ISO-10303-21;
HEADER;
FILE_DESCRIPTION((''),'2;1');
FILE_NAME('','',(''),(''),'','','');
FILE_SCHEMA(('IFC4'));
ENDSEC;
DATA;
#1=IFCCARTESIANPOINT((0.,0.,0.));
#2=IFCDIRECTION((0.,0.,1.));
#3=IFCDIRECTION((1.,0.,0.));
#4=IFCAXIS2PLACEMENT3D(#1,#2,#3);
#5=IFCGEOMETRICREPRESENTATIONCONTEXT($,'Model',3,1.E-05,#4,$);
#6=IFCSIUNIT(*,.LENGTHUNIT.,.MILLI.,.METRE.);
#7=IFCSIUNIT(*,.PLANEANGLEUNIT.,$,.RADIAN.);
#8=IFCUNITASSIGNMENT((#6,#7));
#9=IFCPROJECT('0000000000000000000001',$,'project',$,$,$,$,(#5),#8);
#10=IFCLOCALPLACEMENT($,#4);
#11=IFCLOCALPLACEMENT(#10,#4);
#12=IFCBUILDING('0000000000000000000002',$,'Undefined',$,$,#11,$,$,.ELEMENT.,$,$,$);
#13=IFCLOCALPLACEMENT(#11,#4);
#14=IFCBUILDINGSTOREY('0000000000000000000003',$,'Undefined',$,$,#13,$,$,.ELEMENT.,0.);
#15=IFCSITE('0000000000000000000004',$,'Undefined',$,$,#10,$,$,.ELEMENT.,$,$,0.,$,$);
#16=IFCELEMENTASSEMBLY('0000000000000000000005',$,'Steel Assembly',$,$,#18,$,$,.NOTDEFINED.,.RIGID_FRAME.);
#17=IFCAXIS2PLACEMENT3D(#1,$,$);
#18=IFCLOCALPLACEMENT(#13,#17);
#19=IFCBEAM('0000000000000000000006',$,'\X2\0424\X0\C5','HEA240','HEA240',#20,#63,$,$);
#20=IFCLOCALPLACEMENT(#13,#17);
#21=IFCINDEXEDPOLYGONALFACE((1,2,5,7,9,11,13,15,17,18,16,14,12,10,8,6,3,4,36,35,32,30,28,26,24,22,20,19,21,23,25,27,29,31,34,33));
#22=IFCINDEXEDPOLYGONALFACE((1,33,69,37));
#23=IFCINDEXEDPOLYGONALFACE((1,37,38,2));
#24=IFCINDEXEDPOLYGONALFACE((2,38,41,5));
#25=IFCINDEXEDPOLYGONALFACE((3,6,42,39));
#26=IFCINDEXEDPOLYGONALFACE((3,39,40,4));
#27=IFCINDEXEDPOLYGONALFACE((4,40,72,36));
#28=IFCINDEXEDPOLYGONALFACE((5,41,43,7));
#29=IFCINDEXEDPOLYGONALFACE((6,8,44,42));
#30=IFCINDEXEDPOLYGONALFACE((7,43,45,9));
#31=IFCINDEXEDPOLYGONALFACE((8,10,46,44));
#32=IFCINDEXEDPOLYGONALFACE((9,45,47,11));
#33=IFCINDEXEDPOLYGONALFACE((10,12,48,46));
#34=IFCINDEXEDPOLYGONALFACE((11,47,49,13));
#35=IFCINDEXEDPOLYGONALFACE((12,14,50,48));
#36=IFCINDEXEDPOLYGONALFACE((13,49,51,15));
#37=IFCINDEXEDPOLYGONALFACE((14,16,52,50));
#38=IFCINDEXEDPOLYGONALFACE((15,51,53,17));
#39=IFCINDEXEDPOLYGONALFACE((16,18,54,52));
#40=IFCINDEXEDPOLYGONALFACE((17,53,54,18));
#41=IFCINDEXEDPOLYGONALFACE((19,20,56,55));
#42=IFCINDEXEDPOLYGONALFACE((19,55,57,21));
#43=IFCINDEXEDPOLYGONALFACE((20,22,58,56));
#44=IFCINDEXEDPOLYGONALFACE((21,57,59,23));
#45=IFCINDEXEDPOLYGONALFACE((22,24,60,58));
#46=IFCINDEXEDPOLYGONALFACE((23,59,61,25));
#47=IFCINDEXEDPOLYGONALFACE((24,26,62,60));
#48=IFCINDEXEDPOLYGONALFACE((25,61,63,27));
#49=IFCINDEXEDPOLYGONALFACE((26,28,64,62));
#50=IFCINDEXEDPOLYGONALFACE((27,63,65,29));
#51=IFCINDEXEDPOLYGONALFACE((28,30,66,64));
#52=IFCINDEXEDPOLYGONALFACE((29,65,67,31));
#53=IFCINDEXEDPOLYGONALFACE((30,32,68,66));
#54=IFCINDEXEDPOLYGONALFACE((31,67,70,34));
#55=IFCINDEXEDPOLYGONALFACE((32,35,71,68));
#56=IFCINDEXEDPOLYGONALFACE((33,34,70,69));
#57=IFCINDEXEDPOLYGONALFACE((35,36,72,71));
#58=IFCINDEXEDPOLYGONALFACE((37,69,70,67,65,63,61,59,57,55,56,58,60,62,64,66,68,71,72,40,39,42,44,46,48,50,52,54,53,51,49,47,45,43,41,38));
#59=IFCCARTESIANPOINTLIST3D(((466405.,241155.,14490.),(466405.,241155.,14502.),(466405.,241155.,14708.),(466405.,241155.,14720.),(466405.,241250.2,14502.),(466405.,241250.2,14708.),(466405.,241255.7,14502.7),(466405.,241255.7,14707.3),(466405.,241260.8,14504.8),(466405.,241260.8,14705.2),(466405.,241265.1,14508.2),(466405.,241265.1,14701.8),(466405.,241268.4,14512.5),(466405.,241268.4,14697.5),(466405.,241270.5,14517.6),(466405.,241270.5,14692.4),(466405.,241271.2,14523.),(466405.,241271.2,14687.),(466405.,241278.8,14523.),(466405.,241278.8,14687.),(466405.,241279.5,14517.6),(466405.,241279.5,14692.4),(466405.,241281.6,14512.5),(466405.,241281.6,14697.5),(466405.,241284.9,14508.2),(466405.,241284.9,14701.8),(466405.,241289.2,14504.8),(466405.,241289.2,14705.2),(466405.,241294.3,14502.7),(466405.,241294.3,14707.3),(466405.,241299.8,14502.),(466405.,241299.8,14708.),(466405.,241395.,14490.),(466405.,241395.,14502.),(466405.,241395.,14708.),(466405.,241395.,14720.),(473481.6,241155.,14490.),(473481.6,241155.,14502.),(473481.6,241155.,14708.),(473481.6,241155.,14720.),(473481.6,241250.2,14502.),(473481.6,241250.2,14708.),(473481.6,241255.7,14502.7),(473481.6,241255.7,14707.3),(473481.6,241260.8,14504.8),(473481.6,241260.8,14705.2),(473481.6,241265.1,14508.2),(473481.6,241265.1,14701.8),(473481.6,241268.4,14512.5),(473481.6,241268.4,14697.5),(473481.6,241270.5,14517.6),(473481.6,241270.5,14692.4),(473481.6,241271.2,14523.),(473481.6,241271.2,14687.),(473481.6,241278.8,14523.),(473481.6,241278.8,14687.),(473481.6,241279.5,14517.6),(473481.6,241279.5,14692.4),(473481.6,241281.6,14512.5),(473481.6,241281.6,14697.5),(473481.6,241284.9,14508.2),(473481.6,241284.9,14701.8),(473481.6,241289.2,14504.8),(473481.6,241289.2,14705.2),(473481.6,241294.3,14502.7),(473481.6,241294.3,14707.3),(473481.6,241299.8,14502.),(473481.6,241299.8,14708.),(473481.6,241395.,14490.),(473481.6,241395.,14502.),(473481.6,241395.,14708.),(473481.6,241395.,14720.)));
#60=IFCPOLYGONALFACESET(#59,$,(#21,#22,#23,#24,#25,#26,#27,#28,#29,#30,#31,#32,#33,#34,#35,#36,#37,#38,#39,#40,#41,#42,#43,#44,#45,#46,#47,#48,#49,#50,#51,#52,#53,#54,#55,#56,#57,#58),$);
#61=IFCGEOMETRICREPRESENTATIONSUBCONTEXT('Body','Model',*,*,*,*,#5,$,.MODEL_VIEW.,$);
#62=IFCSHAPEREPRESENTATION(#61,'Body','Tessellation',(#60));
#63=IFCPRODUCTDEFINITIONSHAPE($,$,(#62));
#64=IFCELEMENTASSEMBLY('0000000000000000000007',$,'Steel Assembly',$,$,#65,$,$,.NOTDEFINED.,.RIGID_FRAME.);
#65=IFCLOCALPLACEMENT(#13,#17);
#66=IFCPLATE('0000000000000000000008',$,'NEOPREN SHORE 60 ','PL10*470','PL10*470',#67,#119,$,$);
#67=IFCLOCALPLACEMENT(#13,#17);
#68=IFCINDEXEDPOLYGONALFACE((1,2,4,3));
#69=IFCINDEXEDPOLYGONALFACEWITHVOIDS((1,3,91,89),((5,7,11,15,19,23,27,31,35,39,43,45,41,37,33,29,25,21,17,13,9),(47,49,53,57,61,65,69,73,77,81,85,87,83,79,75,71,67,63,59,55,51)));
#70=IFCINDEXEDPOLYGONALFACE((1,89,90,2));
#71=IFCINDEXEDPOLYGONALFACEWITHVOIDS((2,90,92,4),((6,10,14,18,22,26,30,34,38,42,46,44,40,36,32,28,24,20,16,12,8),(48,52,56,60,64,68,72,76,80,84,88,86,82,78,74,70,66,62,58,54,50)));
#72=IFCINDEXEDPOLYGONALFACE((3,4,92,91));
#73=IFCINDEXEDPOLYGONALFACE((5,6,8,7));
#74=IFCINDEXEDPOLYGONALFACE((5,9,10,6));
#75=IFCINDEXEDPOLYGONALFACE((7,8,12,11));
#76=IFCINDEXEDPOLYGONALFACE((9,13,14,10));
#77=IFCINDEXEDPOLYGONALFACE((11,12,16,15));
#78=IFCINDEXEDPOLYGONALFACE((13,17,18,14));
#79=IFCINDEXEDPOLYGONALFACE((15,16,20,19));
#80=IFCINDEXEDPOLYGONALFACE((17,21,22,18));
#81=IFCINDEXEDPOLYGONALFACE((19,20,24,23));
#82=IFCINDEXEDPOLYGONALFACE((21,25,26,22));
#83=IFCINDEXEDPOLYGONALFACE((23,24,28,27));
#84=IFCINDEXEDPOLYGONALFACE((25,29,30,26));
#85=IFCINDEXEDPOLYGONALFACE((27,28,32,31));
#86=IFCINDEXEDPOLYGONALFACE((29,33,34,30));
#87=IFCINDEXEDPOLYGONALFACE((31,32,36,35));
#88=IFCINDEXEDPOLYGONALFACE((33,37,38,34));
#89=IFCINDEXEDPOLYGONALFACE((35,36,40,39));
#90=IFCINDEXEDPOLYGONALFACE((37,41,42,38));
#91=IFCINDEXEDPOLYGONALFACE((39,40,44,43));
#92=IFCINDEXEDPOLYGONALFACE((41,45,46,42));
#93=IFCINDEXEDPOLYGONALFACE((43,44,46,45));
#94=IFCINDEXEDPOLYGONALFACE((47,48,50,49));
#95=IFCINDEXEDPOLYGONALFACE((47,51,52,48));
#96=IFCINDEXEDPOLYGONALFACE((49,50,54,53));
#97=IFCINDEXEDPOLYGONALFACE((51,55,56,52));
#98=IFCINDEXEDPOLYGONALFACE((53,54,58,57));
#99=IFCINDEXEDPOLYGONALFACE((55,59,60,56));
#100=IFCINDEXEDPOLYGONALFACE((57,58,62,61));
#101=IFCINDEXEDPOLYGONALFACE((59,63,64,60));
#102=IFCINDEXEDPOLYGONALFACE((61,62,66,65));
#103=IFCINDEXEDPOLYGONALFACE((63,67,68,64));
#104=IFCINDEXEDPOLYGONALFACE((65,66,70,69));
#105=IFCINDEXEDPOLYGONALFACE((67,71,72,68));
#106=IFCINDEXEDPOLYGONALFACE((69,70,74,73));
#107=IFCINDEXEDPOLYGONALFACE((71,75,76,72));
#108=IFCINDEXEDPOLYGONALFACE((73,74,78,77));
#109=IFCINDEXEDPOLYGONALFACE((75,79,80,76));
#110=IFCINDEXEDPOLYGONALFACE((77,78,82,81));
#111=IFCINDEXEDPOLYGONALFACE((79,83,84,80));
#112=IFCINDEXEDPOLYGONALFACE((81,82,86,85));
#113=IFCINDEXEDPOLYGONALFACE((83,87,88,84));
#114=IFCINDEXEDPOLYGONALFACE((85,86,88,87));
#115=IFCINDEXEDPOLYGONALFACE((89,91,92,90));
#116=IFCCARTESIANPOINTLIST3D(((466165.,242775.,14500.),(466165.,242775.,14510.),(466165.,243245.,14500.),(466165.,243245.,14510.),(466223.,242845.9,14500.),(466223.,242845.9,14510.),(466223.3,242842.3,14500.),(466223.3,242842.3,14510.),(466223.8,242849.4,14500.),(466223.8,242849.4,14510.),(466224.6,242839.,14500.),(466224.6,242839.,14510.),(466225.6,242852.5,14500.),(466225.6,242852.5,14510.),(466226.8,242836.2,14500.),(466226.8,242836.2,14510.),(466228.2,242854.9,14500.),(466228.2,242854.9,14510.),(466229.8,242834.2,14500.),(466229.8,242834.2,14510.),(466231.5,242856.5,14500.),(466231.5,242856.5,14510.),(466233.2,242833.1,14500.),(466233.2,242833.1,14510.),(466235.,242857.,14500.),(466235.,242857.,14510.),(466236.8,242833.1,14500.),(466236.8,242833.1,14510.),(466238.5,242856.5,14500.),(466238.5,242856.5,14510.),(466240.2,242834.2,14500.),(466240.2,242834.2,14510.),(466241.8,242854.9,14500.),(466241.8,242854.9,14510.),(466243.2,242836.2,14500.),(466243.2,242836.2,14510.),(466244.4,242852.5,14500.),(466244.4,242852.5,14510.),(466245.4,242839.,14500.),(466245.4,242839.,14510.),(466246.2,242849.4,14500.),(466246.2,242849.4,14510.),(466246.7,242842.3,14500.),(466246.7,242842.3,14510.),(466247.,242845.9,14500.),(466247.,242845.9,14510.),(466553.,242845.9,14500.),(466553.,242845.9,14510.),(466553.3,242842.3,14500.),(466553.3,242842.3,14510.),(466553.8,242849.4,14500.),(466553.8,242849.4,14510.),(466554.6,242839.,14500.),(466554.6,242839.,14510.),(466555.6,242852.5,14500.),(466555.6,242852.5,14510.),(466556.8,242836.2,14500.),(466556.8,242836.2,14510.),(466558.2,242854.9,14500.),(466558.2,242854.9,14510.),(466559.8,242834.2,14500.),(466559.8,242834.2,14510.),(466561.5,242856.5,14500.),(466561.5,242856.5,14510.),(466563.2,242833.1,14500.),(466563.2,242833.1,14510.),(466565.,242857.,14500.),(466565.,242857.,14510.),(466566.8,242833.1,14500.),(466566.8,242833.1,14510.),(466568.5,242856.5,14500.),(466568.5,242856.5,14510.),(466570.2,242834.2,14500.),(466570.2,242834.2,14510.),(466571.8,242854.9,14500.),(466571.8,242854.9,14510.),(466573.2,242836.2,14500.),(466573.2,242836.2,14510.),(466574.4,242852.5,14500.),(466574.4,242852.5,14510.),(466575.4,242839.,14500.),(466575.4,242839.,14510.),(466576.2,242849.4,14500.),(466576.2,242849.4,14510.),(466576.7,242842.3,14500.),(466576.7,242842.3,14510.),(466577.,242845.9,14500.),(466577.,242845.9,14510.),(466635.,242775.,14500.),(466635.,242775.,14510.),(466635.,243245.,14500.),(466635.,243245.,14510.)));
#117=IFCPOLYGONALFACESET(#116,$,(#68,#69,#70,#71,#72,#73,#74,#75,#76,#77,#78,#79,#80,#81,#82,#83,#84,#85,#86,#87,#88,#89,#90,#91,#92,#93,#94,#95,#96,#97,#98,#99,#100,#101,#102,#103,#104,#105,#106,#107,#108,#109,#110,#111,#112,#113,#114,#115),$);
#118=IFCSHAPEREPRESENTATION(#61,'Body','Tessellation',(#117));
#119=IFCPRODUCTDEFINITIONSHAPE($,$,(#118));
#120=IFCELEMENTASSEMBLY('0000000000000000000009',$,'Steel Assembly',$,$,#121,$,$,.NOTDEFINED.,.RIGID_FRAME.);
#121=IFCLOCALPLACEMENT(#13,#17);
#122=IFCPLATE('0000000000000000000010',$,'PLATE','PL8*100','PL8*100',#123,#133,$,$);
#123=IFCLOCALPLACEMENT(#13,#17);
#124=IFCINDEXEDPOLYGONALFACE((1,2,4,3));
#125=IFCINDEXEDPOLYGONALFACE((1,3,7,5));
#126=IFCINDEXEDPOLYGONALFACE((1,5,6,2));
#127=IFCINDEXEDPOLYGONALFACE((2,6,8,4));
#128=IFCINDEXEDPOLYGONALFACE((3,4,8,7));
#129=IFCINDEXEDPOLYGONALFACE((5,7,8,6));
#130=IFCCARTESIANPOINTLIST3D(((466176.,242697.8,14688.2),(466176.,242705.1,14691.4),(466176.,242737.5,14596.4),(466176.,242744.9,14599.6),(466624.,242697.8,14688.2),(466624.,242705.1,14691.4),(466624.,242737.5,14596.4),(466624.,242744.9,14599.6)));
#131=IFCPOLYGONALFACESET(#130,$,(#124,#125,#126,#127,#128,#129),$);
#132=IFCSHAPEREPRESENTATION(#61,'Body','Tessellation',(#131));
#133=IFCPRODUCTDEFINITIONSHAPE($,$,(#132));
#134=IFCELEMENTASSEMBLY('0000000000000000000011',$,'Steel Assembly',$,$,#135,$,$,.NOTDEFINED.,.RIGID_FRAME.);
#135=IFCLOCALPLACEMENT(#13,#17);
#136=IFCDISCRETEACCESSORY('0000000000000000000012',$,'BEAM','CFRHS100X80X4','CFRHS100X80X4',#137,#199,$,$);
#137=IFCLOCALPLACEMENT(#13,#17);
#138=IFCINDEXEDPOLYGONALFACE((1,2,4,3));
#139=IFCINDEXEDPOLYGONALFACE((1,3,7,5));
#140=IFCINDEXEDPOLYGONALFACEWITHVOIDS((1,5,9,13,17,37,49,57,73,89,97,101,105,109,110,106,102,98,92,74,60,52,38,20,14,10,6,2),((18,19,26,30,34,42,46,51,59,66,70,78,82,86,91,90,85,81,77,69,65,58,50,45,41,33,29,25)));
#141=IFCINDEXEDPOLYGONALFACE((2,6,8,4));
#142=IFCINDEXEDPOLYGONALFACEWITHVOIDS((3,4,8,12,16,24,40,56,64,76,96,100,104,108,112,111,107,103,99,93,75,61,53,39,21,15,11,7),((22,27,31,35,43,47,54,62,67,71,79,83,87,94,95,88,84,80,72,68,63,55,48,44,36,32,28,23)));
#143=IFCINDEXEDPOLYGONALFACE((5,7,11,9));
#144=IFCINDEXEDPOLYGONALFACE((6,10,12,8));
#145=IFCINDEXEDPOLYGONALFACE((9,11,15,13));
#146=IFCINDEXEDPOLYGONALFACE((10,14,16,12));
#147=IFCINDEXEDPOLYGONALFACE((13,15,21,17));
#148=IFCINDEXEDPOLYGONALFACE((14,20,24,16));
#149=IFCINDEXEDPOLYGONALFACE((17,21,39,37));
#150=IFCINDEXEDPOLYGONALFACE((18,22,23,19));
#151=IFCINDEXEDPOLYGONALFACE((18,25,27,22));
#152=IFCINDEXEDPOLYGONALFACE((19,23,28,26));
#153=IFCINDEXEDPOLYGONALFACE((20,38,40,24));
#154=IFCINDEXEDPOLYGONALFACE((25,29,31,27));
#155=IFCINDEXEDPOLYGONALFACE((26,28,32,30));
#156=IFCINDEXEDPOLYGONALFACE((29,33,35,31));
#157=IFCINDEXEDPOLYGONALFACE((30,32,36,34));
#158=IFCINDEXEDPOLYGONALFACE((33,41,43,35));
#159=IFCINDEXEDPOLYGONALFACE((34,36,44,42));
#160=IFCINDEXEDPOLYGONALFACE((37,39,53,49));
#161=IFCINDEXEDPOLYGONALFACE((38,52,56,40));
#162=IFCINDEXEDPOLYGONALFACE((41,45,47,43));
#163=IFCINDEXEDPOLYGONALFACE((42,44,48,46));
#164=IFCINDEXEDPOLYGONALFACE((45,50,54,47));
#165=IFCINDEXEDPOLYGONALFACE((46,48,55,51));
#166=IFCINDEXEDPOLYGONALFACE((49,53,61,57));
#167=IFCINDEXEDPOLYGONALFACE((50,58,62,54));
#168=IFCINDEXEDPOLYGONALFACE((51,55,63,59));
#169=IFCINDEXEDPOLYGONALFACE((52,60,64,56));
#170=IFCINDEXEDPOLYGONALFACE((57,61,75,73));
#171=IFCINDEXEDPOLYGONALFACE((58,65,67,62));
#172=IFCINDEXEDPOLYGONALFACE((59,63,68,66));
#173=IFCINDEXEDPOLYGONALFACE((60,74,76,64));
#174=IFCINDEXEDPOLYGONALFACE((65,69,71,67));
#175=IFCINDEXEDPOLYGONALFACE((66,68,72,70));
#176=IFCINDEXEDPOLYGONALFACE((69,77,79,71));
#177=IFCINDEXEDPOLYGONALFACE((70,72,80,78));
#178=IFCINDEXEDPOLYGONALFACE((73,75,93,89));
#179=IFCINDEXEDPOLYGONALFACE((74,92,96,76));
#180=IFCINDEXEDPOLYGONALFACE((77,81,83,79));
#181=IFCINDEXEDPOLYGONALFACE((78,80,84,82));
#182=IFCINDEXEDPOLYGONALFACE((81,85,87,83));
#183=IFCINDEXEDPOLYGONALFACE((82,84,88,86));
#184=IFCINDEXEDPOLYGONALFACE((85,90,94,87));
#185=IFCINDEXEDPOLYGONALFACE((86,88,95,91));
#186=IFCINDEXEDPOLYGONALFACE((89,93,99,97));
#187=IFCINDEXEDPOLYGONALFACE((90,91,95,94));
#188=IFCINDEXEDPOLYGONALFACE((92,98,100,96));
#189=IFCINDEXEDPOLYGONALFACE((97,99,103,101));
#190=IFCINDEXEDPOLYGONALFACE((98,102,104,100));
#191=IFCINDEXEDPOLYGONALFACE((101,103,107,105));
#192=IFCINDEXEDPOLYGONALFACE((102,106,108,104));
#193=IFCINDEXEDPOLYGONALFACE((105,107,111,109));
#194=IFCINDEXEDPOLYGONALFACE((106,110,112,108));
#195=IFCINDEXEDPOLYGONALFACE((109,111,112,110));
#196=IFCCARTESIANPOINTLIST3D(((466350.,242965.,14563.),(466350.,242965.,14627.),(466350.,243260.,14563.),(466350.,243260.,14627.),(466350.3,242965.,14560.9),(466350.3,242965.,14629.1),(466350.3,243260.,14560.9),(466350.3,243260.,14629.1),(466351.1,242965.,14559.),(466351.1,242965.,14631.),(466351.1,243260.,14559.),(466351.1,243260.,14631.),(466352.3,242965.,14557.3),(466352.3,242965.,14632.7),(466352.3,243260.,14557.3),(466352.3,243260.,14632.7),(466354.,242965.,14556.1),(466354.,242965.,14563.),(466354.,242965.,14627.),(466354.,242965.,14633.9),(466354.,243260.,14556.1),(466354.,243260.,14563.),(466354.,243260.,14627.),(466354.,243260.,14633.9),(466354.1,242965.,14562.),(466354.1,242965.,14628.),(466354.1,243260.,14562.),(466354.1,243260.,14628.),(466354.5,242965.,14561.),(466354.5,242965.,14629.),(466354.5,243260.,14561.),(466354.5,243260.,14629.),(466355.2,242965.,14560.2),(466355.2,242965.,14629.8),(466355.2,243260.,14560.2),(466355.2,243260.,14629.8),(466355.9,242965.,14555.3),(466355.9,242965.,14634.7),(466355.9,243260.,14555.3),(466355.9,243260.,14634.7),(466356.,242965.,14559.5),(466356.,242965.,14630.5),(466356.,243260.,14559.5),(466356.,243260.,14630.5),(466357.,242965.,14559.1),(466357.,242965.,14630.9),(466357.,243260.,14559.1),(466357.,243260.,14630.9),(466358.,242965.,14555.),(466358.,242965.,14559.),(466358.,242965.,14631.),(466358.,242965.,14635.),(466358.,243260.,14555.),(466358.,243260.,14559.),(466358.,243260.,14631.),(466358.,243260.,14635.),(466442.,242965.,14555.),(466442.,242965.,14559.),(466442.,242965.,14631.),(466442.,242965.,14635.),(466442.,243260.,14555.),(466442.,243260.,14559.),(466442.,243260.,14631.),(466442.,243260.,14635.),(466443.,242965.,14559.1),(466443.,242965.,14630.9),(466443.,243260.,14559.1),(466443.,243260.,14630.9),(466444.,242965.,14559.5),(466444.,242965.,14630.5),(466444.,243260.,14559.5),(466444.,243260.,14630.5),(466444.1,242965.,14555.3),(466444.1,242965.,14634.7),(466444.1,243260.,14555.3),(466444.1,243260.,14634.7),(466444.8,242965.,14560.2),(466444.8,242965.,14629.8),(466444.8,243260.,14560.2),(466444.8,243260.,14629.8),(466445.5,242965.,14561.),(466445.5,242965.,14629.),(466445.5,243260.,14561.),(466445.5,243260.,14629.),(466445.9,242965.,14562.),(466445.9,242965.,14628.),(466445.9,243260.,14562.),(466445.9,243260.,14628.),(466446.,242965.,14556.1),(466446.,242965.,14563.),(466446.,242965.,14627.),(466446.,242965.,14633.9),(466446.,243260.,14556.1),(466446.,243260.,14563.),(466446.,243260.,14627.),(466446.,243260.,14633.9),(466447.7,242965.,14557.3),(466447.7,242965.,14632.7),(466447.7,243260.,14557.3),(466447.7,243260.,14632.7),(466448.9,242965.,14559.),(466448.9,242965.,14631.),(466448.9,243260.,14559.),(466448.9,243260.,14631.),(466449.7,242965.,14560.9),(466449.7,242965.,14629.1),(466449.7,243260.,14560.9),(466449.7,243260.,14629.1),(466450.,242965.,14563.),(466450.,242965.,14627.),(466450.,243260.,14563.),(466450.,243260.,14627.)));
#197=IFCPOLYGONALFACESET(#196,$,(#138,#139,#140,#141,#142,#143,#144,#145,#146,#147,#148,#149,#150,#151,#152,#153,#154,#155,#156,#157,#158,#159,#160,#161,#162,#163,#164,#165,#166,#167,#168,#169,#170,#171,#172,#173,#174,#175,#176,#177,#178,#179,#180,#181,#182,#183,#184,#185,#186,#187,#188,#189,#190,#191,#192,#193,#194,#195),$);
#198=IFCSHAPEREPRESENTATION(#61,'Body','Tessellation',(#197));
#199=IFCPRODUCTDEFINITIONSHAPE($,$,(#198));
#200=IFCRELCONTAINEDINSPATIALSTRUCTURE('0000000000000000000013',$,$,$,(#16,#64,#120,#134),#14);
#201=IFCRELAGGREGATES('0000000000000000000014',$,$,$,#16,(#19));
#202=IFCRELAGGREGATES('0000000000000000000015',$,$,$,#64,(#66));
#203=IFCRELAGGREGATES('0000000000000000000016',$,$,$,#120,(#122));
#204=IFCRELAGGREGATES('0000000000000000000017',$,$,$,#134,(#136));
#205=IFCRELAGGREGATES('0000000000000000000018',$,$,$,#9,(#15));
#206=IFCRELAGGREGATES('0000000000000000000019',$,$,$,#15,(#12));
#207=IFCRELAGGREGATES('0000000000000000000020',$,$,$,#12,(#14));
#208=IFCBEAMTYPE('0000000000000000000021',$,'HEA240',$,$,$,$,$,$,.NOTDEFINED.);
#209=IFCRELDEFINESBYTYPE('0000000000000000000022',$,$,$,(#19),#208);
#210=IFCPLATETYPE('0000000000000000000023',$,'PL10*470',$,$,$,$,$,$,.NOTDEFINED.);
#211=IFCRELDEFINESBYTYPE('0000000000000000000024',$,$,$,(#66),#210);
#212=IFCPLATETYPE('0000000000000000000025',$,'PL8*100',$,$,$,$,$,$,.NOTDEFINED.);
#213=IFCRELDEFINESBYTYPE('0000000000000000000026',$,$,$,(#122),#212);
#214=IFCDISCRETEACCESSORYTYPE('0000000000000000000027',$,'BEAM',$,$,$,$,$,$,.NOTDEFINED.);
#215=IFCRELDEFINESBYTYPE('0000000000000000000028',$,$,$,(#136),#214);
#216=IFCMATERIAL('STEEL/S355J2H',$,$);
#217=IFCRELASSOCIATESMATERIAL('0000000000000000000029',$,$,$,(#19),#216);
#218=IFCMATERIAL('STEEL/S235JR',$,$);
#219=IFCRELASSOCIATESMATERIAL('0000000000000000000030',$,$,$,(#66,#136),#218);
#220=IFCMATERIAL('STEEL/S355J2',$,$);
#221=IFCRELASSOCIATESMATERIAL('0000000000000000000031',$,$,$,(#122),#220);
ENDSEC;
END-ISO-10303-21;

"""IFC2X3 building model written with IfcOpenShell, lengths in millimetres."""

from ifc_helpers import new_model, si_unit, frame, origin_with_axes, origin_2d_with_axis, place, context, subcontext, project, spatial, polyline, hollow_rectangle, circle, i_section, outline, extrude, boolean, material, type_object, element, aggregate, save


model = new_model("IFC2X3")

# Units and contexts
model_context = context("Model", 3, precision=1e-05, world=origin_with_axes())
body_context = subcontext(model_context, "Body", "Model", "MODEL_VIEW")
ifc_project = project(units=[si_unit("LENGTHUNIT", "METRE", prefix="MILLI"), si_unit("PLANEANGLEUNIT", "RADIAN")], contexts=[model_context])

# Site, building, storey
site_placement = place(None, origin_with_axes())
site = spatial("IfcSite", under=ifc_project, at=site_placement, Name="Undefined", CompositionType="ELEMENT", RefElevation=0.0)
building_placement = place(site_placement, origin_with_axes())
building = spatial("IfcBuilding", under=site, at=building_placement, Name="Undefined", CompositionType="ELEMENT")
storey_placement = place(building_placement, origin_with_axes())
storey = spatial("IfcBuildingStorey", under=building, at=storey_placement, Name="Undefined", CompositionType="ELEMENT", Elevation=0.0)

# Shared definitions
ifc_material_1 = material(Name="STEEL/S235JR")

# Element assembly, beam
ifc_material_2 = material(Name="STEEL/S355J2H")
beam_type_1 = type_object("IfcBeamType", Name="HEA240", PredefinedType="NOTDEFINED")
assembly_1_placement = place(storey_placement, origin_with_axes())
assembly_1 = element("IfcElementAssembly", 1, at=assembly_1_placement, inside=storey, Name="Steel Assembly", AssemblyPlace="NOTDEFINED", PredefinedType="RIGID_FRAME")
beam_1_placement = place(assembly_1_placement, frame((466405.0, 241275.0, 14605.0), z_axis=(0.0, 0.0, 1.0), x_axis=(1.0, 0.0, 0.0)))
beam_1 = element("IfcBeam", 2, at=beam_1_placement, type_object=beam_type_1, material=ifc_material_2, Name="ФC5", Description="HEA240", ObjectType="HEA240", context=body_context, shape_type="SweptSolid", body=[
    extrude(i_section(OverallWidth=240.0, OverallDepth=230.0, WebThickness=7.5, FlangeThickness=12.0, FilletRadius=21.0, at=origin_2d_with_axis()), frame((7076.6, 0.0, 0.0), z_axis=(-1.0, 0.0, 0.0), x_axis=(0.0, -1.0, 0.0)), (0.0, 0.0, 1.0), 7076.6),
])
aggregate(assembly_1, [beam_1])

# Element assemblies, plates
assembly_2_placement = place(storey_placement, origin_with_axes())
assembly_2 = element("IfcElementAssembly", 3, at=assembly_2_placement, inside=storey, Name="Steel Assembly", AssemblyPlace="NOTDEFINED", PredefinedType="RIGID_FRAME")
plate_type_1 = type_object("IfcPlateType", Name="PL10*470", PredefinedType="NOTDEFINED")
plate_1_placement = place(assembly_2_placement, frame((466165.0, 242775.0, 14505.0), z_axis=(0.0, 0.0, 1.0), x_axis=(1.0, 0.0, 0.0)))
plate_1 = element("IfcPlate", 4, at=plate_1_placement, type_object=plate_type_1, material=ifc_material_1, Name="NEOPREN SHORE 60 ", Description="PL10*470", ObjectType="PL10*470", context=body_context, shape_type="CSG", body=[
    boolean("DIFFERENCE", boolean("DIFFERENCE", extrude(outline(polyline([(0.0, 0.0), (470.0, 0.0), (470.0, 470.0), (0.0, 470.0), (0.0, 0.0)])), frame((0.0, 0.0, -5.0), z_axis=(0.0, 0.0, 1.0), x_axis=(1.0, 0.0, 0.0)), (0.0, 0.0, 1.0), 10.0), extrude(circle(Radius=12.0, at=origin_2d_with_axis()), frame((400.0, 70.0, 95.0), z_axis=(0.0, 0.0, -1.0), x_axis=(0.0, 1.0, 0.0)), (0.0, 0.0, 1.0), 170.0)), extrude(circle(Radius=12.0, at=origin_2d_with_axis()), frame((70.0, 70.0, 95.0), z_axis=(0.0, 0.0, -1.0), x_axis=(0.0, 1.0, 0.0)), (0.0, 0.0, 1.0), 170.0)),
])
aggregate(assembly_2, [plate_1])
assembly_3_placement = place(storey_placement, origin_with_axes())
assembly_3 = element("IfcElementAssembly", 5, at=assembly_3_placement, inside=storey, Name="Steel Assembly", AssemblyPlace="NOTDEFINED", PredefinedType="RIGID_FRAME")
ifc_material_3 = material(Name="STEEL/S355J2")
plate_type_2 = type_object("IfcPlateType", Name="PL8*100", PredefinedType="NOTDEFINED")
plate_2_placement = place(assembly_3_placement, frame((466176.0, 242741.2, 14598.0), z_axis=(0.0, 0.917713, 0.397244), x_axis=(0.0, -0.397244, 0.917713)))
plate_2 = element("IfcPlate", 6, at=plate_2_placement, type_object=plate_type_2, material=ifc_material_3, Name="PLATE", Description="PL8*100", ObjectType="PL8*100", context=body_context, shape_type="SweptSolid", body=[
    extrude(outline(polyline([(0.0, 0.0), (100.0, 0.0), (100.0, 448.0), (0.0, 448.0), (0.0, 0.0)])), frame((0.0, 0.0, -4.0), z_axis=(0.0, 0.0, 1.0), x_axis=(1.0, 0.0, 0.0)), (0.0, 0.0, 1.0), 8.0),
])
aggregate(assembly_3, [plate_2])

# Element assembly, discrete accessory
assembly_4_placement = place(storey_placement, origin_with_axes())
assembly_4 = element("IfcElementAssembly", 7, at=assembly_4_placement, inside=storey, Name="Steel Assembly", AssemblyPlace="NOTDEFINED", PredefinedType="RIGID_FRAME")
discrete_accessory_type_1 = type_object("IfcDiscreteAccessoryType", Name="BEAM")
discrete_accessory_1_placement = place(assembly_4_placement, frame((466400.0, 242965.0, 14595.0), z_axis=(1.0, 0.0, 0.0), x_axis=(0.0, 1.0, 0.0)))
discrete_accessory_1 = element("IfcDiscreteAccessory", 8, at=discrete_accessory_1_placement, type_object=discrete_accessory_type_1, material=ifc_material_1, Name="BEAM", Description="CFRHS100X80X4", ObjectType="CFRHS100X80X4", context=body_context, shape_type="SweptSolid", body=[
    extrude(hollow_rectangle(XDim=80.0, YDim=100.0, WallThickness=4.0, InnerFilletRadius=4.0, OuterFilletRadius=8.0, at=origin_2d_with_axis()), frame((295.0, 0.0, 0.0), z_axis=(-1.0, 0.0, 0.0), x_axis=(0.0, -1.0, 0.0)), (0.0, 0.0, 1.0), 295.0),
])

aggregate(assembly_4, [discrete_accessory_1])

save(model, "model.ifc")
